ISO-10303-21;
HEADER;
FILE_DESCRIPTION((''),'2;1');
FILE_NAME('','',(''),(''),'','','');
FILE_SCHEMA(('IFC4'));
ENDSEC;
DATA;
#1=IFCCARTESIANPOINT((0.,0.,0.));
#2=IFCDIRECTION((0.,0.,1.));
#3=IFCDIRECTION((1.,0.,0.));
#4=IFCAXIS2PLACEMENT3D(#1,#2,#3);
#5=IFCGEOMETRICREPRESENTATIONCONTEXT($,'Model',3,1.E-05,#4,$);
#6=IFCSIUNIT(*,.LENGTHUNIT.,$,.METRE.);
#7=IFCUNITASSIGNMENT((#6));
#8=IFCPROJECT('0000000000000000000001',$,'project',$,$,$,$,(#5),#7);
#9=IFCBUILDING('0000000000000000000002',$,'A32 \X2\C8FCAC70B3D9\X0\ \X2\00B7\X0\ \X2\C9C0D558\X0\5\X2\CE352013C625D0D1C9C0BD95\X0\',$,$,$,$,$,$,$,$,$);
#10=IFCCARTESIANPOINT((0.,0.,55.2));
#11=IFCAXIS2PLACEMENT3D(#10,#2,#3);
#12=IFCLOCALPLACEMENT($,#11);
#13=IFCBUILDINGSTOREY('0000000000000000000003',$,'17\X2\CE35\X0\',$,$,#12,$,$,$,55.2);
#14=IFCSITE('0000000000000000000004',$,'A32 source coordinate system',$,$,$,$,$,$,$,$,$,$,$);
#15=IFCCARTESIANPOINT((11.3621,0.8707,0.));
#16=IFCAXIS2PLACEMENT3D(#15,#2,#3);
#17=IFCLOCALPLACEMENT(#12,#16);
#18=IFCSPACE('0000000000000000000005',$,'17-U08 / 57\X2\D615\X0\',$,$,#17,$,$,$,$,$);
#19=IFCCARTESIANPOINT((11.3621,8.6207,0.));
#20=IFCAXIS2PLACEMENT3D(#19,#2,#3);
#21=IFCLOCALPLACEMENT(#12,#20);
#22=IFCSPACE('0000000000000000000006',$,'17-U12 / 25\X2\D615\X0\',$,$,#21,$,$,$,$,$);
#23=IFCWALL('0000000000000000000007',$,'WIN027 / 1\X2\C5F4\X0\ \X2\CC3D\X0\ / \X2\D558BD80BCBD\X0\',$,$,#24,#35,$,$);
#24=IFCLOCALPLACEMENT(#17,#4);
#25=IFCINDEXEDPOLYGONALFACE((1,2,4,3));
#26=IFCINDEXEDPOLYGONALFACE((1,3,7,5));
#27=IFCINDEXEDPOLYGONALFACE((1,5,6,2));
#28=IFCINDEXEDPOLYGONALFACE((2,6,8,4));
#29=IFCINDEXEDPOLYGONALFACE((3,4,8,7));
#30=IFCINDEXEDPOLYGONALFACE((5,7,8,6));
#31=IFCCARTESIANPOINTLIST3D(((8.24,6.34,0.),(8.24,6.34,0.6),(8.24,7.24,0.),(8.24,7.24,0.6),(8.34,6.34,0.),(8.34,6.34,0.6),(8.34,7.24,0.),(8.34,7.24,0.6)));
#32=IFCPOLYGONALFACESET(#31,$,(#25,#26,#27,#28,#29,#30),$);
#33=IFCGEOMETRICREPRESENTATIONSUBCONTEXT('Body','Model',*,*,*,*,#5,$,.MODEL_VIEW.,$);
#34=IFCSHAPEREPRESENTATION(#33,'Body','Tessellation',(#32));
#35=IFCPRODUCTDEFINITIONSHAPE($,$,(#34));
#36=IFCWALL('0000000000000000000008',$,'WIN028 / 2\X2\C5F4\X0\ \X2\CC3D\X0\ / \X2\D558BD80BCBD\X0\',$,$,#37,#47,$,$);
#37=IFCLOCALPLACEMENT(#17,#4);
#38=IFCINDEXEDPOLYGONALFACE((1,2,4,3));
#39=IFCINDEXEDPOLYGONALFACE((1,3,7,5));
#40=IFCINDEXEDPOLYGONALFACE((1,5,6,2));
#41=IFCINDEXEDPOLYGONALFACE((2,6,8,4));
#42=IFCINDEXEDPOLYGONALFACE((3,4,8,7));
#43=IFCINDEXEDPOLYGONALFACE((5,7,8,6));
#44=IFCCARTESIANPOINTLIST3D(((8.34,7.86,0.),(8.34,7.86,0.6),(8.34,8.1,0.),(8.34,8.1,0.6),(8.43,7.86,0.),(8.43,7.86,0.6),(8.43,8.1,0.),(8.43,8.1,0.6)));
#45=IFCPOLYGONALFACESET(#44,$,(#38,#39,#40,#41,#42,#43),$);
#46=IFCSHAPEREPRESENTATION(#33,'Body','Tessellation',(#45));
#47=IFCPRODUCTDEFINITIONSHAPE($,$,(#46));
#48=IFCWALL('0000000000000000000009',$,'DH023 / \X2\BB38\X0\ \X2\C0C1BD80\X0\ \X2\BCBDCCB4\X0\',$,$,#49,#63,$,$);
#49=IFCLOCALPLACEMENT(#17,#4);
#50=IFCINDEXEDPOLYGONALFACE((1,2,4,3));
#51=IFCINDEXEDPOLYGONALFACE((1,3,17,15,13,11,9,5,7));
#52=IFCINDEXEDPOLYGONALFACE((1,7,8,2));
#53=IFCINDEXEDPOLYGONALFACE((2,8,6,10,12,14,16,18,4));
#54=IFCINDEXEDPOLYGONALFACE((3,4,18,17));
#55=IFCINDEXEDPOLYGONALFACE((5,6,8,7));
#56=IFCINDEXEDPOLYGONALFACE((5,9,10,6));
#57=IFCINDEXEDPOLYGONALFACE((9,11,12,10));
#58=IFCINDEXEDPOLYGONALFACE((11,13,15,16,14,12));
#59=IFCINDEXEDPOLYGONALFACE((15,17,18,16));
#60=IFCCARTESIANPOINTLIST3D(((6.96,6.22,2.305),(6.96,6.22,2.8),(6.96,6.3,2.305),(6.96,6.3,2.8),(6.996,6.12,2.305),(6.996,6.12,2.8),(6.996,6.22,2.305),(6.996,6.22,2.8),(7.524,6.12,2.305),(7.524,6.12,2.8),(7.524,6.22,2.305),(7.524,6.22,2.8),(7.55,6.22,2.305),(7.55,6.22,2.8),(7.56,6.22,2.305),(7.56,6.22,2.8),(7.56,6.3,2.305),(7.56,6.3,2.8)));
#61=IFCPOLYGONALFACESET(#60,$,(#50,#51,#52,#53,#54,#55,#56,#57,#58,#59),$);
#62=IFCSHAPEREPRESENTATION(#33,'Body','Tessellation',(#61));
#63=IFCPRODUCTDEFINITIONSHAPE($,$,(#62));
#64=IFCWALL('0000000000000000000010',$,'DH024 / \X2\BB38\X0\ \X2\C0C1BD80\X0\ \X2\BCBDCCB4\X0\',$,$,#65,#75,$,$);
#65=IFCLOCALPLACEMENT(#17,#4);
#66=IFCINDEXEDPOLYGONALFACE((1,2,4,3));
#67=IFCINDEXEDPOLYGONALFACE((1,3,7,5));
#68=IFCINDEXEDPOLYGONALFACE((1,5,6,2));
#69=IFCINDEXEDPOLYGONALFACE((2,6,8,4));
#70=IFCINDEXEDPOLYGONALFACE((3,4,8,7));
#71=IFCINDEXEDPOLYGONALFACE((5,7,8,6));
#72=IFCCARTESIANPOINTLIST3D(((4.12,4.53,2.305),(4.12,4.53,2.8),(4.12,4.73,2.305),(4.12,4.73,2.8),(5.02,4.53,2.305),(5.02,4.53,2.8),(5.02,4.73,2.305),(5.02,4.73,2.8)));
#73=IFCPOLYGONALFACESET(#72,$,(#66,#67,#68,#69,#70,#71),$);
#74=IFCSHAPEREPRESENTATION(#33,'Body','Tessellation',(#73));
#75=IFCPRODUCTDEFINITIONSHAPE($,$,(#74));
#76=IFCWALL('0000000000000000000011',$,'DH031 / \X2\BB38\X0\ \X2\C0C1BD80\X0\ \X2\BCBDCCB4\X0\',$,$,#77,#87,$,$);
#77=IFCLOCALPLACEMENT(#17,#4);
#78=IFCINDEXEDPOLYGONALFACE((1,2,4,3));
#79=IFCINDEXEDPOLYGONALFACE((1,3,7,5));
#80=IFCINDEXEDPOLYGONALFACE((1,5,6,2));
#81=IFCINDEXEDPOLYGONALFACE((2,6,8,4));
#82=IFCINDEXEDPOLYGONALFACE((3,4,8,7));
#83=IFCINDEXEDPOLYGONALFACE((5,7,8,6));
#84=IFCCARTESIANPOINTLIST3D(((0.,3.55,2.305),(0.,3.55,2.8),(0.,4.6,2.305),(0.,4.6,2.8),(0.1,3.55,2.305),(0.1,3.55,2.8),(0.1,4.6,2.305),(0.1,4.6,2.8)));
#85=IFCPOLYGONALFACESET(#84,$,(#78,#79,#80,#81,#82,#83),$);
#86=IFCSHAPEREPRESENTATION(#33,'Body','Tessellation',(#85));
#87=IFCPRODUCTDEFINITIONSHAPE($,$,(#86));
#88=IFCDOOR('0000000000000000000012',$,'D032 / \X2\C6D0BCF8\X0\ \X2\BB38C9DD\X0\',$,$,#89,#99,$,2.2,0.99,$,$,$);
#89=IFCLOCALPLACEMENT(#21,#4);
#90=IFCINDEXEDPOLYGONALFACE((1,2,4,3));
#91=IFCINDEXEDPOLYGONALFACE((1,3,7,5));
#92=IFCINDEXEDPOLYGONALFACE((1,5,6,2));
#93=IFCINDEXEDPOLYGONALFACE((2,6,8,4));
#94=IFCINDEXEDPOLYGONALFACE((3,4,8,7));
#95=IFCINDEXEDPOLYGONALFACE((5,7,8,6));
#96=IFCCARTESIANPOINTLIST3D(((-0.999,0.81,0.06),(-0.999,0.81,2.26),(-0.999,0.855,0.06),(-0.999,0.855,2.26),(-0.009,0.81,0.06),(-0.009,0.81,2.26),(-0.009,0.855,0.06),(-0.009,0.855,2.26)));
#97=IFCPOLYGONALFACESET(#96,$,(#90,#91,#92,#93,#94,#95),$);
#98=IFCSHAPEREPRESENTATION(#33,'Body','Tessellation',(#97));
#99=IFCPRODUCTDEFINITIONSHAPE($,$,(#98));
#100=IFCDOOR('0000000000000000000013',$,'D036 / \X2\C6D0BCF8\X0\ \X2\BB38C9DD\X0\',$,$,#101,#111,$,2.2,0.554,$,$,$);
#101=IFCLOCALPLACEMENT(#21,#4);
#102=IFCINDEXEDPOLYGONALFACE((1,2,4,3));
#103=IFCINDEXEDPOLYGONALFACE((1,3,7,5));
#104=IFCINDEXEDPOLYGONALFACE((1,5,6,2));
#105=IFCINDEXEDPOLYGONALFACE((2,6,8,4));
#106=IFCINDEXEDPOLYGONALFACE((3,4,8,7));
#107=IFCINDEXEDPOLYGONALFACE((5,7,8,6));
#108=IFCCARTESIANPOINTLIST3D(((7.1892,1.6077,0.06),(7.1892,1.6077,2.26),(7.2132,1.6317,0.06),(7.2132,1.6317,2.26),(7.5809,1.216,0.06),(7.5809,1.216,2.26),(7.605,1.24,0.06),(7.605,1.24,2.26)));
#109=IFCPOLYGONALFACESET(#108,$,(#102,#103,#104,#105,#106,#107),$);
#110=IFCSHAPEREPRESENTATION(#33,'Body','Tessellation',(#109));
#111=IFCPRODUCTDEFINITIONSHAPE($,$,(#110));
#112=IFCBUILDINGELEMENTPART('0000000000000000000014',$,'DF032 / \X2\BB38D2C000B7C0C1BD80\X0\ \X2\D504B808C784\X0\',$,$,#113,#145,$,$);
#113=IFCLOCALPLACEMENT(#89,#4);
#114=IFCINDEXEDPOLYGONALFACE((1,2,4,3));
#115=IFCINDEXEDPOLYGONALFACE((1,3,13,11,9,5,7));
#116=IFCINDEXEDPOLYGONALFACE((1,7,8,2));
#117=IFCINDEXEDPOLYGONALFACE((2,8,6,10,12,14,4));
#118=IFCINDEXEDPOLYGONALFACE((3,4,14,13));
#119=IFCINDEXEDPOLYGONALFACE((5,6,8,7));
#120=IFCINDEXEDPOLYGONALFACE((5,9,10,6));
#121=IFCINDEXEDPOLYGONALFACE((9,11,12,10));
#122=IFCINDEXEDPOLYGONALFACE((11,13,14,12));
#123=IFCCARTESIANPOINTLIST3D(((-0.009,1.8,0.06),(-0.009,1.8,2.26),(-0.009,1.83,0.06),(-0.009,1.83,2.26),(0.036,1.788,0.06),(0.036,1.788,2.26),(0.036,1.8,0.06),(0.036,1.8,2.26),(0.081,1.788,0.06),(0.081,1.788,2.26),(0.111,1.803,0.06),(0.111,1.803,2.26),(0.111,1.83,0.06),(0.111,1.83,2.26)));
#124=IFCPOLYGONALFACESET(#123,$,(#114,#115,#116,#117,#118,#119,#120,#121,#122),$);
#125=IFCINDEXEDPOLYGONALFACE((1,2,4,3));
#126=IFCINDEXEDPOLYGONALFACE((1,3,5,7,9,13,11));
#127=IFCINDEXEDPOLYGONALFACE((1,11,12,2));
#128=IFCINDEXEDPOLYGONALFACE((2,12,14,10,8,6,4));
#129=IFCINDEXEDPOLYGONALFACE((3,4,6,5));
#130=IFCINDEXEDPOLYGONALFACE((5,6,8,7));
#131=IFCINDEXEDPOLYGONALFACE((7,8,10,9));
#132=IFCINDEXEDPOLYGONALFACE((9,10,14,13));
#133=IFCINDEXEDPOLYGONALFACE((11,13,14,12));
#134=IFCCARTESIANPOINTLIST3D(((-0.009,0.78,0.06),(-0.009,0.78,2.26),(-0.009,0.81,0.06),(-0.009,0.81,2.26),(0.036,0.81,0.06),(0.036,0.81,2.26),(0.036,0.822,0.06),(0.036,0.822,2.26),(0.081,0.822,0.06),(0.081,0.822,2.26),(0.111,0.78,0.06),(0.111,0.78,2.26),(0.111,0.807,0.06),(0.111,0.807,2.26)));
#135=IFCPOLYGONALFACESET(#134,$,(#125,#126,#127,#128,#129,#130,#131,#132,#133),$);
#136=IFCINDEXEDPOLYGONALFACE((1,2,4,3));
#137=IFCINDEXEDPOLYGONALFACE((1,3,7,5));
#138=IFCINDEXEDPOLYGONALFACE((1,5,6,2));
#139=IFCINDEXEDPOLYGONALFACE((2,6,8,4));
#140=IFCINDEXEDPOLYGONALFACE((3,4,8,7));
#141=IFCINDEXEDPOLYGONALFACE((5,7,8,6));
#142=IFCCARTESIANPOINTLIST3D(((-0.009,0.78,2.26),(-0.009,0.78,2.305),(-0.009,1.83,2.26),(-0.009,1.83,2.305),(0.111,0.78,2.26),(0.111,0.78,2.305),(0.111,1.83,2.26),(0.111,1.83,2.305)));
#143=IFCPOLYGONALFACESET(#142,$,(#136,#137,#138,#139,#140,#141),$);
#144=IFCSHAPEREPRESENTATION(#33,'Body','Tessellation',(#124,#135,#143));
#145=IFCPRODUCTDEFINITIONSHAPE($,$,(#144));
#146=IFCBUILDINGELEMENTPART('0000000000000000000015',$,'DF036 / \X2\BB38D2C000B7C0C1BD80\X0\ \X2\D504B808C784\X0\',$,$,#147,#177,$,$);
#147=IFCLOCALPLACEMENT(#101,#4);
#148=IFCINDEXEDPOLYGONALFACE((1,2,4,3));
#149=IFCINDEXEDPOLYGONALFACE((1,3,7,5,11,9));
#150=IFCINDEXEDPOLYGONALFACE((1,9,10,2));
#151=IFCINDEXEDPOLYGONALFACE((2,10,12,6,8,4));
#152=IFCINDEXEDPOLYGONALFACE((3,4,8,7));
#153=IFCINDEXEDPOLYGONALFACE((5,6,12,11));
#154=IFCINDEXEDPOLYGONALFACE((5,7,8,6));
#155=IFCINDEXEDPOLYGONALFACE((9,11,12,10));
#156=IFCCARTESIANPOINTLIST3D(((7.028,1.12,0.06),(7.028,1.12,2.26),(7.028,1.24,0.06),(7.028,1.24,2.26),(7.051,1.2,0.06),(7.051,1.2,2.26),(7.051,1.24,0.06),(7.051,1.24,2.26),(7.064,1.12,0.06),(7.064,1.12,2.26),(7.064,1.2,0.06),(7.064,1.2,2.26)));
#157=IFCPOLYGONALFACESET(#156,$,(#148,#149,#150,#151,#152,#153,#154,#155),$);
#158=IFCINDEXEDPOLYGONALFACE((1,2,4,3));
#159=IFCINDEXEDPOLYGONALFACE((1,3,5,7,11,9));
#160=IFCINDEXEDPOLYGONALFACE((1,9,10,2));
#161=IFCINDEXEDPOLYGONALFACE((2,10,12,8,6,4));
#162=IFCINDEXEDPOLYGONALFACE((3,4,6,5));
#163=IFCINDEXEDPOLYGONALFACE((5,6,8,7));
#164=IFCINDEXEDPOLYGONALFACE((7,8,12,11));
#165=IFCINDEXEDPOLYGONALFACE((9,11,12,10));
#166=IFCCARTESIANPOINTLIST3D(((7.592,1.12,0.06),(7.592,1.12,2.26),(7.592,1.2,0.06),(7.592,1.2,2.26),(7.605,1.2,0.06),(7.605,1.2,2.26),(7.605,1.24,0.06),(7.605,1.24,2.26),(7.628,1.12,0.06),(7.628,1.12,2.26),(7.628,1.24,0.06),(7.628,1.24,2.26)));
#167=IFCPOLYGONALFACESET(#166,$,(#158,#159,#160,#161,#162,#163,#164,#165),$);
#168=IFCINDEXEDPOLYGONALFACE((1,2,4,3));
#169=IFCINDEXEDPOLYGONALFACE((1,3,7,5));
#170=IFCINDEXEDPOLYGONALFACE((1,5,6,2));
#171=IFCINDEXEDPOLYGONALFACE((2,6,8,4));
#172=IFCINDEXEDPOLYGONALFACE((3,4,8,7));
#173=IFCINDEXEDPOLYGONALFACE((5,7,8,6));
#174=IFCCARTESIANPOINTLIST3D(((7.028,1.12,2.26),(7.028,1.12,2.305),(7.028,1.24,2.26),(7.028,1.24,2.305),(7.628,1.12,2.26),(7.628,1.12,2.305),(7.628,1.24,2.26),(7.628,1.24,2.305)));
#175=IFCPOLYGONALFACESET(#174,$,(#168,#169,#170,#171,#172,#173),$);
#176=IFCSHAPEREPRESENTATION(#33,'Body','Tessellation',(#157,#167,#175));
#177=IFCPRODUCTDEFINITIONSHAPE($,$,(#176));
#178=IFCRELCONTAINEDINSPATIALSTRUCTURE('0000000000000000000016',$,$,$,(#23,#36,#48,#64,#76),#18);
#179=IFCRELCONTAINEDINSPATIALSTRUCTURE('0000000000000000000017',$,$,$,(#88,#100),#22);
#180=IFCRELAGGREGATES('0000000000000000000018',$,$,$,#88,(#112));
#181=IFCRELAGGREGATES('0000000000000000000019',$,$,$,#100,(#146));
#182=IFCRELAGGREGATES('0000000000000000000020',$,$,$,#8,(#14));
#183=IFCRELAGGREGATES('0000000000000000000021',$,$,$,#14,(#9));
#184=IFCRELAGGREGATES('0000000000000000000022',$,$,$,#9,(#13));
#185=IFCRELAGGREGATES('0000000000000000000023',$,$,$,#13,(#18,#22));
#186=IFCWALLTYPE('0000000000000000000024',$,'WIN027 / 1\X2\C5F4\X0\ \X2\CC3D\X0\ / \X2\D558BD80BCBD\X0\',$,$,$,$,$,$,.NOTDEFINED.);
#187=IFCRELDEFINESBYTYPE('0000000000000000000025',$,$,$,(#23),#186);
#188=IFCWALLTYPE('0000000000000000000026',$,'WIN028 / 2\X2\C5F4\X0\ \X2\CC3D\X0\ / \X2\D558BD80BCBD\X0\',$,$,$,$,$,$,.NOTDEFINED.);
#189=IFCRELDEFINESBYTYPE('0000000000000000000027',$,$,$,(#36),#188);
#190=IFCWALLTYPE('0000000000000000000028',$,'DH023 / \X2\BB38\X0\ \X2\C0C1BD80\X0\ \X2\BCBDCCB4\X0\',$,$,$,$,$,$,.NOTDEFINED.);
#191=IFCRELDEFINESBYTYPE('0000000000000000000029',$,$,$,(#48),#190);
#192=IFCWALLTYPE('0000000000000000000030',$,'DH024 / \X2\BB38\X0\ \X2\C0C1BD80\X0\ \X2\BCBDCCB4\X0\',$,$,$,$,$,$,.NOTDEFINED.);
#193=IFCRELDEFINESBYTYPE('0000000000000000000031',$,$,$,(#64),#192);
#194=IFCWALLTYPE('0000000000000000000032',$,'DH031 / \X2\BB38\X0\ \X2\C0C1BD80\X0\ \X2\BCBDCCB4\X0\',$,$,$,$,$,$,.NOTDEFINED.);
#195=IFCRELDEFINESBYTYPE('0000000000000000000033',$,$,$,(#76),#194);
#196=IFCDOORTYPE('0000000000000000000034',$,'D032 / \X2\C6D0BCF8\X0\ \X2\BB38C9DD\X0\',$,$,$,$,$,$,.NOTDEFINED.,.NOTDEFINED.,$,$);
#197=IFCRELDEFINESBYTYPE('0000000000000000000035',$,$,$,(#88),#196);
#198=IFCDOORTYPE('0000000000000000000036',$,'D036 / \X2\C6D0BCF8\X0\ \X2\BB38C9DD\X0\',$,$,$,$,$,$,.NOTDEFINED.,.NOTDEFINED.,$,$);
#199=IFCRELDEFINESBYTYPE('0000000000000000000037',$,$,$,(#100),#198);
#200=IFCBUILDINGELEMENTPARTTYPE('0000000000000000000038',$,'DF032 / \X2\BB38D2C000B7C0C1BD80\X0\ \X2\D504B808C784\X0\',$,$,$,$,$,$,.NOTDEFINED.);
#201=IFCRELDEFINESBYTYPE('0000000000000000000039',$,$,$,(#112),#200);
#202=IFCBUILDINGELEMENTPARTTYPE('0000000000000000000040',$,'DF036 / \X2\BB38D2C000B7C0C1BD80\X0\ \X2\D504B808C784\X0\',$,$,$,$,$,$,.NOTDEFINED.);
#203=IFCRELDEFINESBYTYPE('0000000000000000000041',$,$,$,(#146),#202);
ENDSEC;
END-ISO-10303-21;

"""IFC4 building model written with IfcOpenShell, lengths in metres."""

from ifc_helpers import new_model, si_unit, frame, origin, origin_with_axes, place, context, subcontext, project, spatial, polyline, outline, extrude, source, transform, mapped, type_object, type_shapes, element, aggregate, save


model = new_model("IFC4")

# Units and contexts
model_context = context("Model", 3, precision=1e-05, world=origin_with_axes())
body_context = subcontext(model_context, "Body", "Model", "MODEL_VIEW")
ifc_project = project(units=[si_unit("LENGTHUNIT", "METRE")], contexts=[model_context])

# Site, building, storey, space
storey_placement = place(None, frame((0.0, 0.0, 55.2), z_axis=(0.0, 0.0, 1.0), x_axis=(1.0, 0.0, 0.0)))
space_1_placement = place(storey_placement, frame((11.3621, 8.6207, 0.0), z_axis=(0.0, 0.0, 1.0), x_axis=(1.0, 0.0, 0.0)))
site = spatial("IfcSite", under=ifc_project, Name="A32 source coordinate system")
building = spatial("IfcBuilding", under=site, Name="A32 주거동 · 지하5층–옥탑지붕")
storey = spatial("IfcBuildingStorey", under=building, at=storey_placement, Name="17층", Elevation=55.2)
space_2_placement = place(storey_placement, frame((11.3621, 0.8707, 0.0), z_axis=(0.0, 0.0, 1.0), x_axis=(1.0, 0.0, 0.0)))
space_2 = spatial("IfcSpace", under=storey, at=space_2_placement, Name="17-U08 / 57형")

# Walls
wall_type_1 = type_object("IfcWallType", Name="WIN027 / 1열 창 / 하부벽", PredefinedType="NOTDEFINED")
shared_shape_1 = source(origin(), body_context, "Body", "SweptSolid", [
    extrude(outline(polyline([(8.24, 6.34), (8.24, 7.24), (8.34, 7.24), (8.34, 6.34), (8.24, 6.34)])), origin(), (0.0, 0.0, 1.0), 0.6),
])
type_shapes(wall_type_1, [shared_shape_1])
wall_1_placement = place(space_2_placement, origin_with_axes())
element("IfcWall", 1, at=wall_1_placement, inside=space_2, type_object=wall_type_1, Name="WIN027 / 1열 창 / 하부벽", context=body_context, shape_type="MappedRepresentation", body=[
    mapped(shared_shape_1, transform((0.0, 0.0, 0.0), scale=1.0)),
])
wall_type_2 = type_object("IfcWallType", Name="WIN028 / 2열 창 / 하부벽", PredefinedType="NOTDEFINED")
shared_shape_2 = source(origin(), body_context, "Body", "SweptSolid", [
    extrude(outline(polyline([(8.34, 7.86), (8.34, 8.1), (8.43, 8.1), (8.43, 7.86), (8.34, 7.86)])), origin(), (0.0, 0.0, 1.0), 0.6),
])
type_shapes(wall_type_2, [shared_shape_2])
wall_2_placement = place(space_2_placement, origin_with_axes())
element("IfcWall", 2, at=wall_2_placement, inside=space_2, type_object=wall_type_2, Name="WIN028 / 2열 창 / 하부벽", context=body_context, shape_type="MappedRepresentation", body=[
    mapped(shared_shape_2, transform((0.0, 0.0, 0.0), scale=1.0)),
])
wall_type_3 = type_object("IfcWallType", Name="DH023 / 문 상부 벽체", PredefinedType="NOTDEFINED")
shared_shape_3 = source(origin(), body_context, "Body", "SweptSolid", [
    extrude(outline(polyline([(6.96, 6.3), (7.56, 6.3), (7.56, 6.22), (7.55, 6.22), (7.524, 6.22), (7.524, 6.12), (6.996, 6.12), (6.996, 6.22), (6.96, 6.22), (6.96, 6.3)])), frame((0.0, 0.0, 2.305)), (0.0, 0.0, 1.0), 0.495),
])
type_shapes(wall_type_3, [shared_shape_3])
wall_3_placement = place(space_2_placement, origin_with_axes())
element("IfcWall", 3, at=wall_3_placement, inside=space_2, type_object=wall_type_3, Name="DH023 / 문 상부 벽체", context=body_context, shape_type="MappedRepresentation", body=[
    mapped(shared_shape_3, transform((0.0, 0.0, 0.0), scale=1.0)),
])
wall_type_4 = type_object("IfcWallType", Name="DH024 / 문 상부 벽체", PredefinedType="NOTDEFINED")
shared_shape_4 = source(origin(), body_context, "Body", "SweptSolid", [
    extrude(outline(polyline([(4.12, 4.73), (5.02, 4.73), (5.02, 4.53), (4.12, 4.53), (4.12, 4.73)])), frame((0.0, 0.0, 2.305)), (0.0, 0.0, 1.0), 0.495),
])
type_shapes(wall_type_4, [shared_shape_4])
wall_4_placement = place(space_2_placement, origin_with_axes())
element("IfcWall", 4, at=wall_4_placement, inside=space_2, type_object=wall_type_4, Name="DH024 / 문 상부 벽체", context=body_context, shape_type="MappedRepresentation", body=[
    mapped(shared_shape_4, transform((0.0, 0.0, 0.0), scale=1.0)),
])
wall_type_5 = type_object("IfcWallType", Name="DH031 / 문 상부 벽체", PredefinedType="NOTDEFINED")
shared_shape_5 = source(origin(), body_context, "Body", "SweptSolid", [
    extrude(outline(polyline([(0.0, 4.6), (0.1, 4.6), (0.1, 3.55), (0.0, 3.55), (0.0, 4.6)])), frame((0.0, 0.0, 2.305)), (0.0, 0.0, 1.0), 0.495),
])
type_shapes(wall_type_5, [shared_shape_5])
wall_5_placement = place(space_2_placement, origin_with_axes())
element("IfcWall", 5, at=wall_5_placement, inside=space_2, type_object=wall_type_5, Name="DH031 / 문 상부 벽체", context=body_context, shape_type="MappedRepresentation", body=[
    mapped(shared_shape_5, transform((0.0, 0.0, 0.0), scale=1.0)),
])

# Shared definitions
space_1 = spatial("IfcSpace", under=storey, at=space_1_placement, Name="17-U12 / 25형")

# Doors
door_type_1 = type_object("IfcDoorType", Name="D032 / 원본 문짝", OperationType="NOTDEFINED", PredefinedType="NOTDEFINED")
shared_shape_6 = source(origin(), body_context, "Body", "SweptSolid", [
    extrude(outline(polyline([(-0.009, 0.81), (-0.999, 0.81), (-0.999, 0.855), (-0.009, 0.855), (-0.009, 0.81)])), frame((0.0, 0.0, 0.06)), (0.0, 0.0, 1.0), 2.2),
])
type_shapes(door_type_1, [shared_shape_6])
door_1_placement = place(space_1_placement, origin_with_axes())
door_1 = element("IfcDoor", 6, at=door_1_placement, inside=space_1, type_object=door_type_1, Name="D032 / 원본 문짝", OverallHeight=2.2, OverallWidth=0.99, context=body_context, shape_type="MappedRepresentation", body=[
    mapped(shared_shape_6, transform((0.0, 0.0, 0.0), scale=1.0)),
])
door_type_2 = type_object("IfcDoorType", Name="D036 / 원본 문짝", OperationType="NOTDEFINED", PredefinedType="NOTDEFINED")
shared_shape_7 = source(origin(), body_context, "Body", "SweptSolid", [
    extrude(outline(polyline([(7.1892, 1.6077), (7.2132, 1.6317), (7.605, 1.24), (7.5809, 1.216), (7.1892, 1.6077)])), frame((0.0, 0.0, 0.06)), (0.0, 0.0, 1.0), 2.2),
])
type_shapes(door_type_2, [shared_shape_7])
door_2_placement = place(space_1_placement, origin_with_axes())
door_2 = element("IfcDoor", 7, at=door_2_placement, inside=space_1, type_object=door_type_2, Name="D036 / 원본 문짝", OverallHeight=2.2, OverallWidth=0.554, context=body_context, shape_type="MappedRepresentation", body=[
    mapped(shared_shape_7, transform((0.0, 0.0, 0.0), scale=1.0)),
])

# Building element parts
building_element_part_type_1 = type_object("IfcBuildingElementPartType", Name="DF032 / 문틀·상부 프레임", PredefinedType="NOTDEFINED")
shared_shape_8 = source(origin(), body_context, "Body", "SweptSolid", [
    extrude(outline(polyline([(0.111, 1.83), (0.111, 1.803), (0.081, 1.788), (0.036, 1.788), (0.036, 1.8), (-0.009, 1.8), (-0.009, 1.83), (0.111, 1.83)])), frame((0.0, 0.0, 0.06)), (0.0, 0.0, 1.0), 2.2),
    extrude(outline(polyline([(-0.009, 0.81), (0.036, 0.81), (0.036, 0.822), (0.081, 0.822), (0.111, 0.807), (0.111, 0.78), (-0.009, 0.78), (-0.009, 0.81)])), frame((0.0, 0.0, 0.06)), (0.0, 0.0, 1.0), 2.2),
    extrude(outline(polyline([(-0.009, 0.78), (-0.009, 1.83), (0.111, 1.83), (0.111, 0.78), (-0.009, 0.78)])), frame((0.0, 0.0, 2.26)), (0.0, 0.0, 1.0), 0.045),
])
type_shapes(building_element_part_type_1, [shared_shape_8])
building_element_part_1_placement = place(door_1_placement, origin_with_axes())
building_element_part_1 = element("IfcBuildingElementPart", 8, at=building_element_part_1_placement, type_object=building_element_part_type_1, Name="DF032 / 문틀·상부 프레임", context=body_context, shape_type="MappedRepresentation", body=[
    mapped(shared_shape_8, transform((0.0, 0.0, 0.0), scale=1.0)),
])
aggregate(door_1, [building_element_part_1])
building_element_part_type_2 = type_object("IfcBuildingElementPartType", Name="DF036 / 문틀·상부 프레임", PredefinedType="NOTDEFINED")
shared_shape_9 = source(origin(), body_context, "Body", "SweptSolid", [
    extrude(outline(polyline([(7.028, 1.24), (7.051, 1.24), (7.051, 1.2), (7.064, 1.2), (7.064, 1.12), (7.028, 1.12), (7.028, 1.24)])), frame((0.0, 0.0, 0.06)), (0.0, 0.0, 1.0), 2.2),
    extrude(outline(polyline([(7.592, 1.12), (7.592, 1.2), (7.605, 1.2), (7.605, 1.24), (7.628, 1.24), (7.628, 1.12), (7.592, 1.12)])), frame((0.0, 0.0, 0.06)), (0.0, 0.0, 1.0), 2.2),
    extrude(outline(polyline([(7.028, 1.12), (7.028, 1.24), (7.628, 1.24), (7.628, 1.12), (7.028, 1.12)])), frame((0.0, 0.0, 2.26)), (0.0, 0.0, 1.0), 0.045),
])
type_shapes(building_element_part_type_2, [shared_shape_9])
building_element_part_2_placement = place(door_2_placement, origin_with_axes())
building_element_part_2 = element("IfcBuildingElementPart", 9, at=building_element_part_2_placement, type_object=building_element_part_type_2, Name="DF036 / 문틀·상부 프레임", context=body_context, shape_type="MappedRepresentation", body=[
    mapped(shared_shape_9, transform((0.0, 0.0, 0.0), scale=1.0)),
])
aggregate(door_2, [building_element_part_2])

save(model, "model.ifc")
